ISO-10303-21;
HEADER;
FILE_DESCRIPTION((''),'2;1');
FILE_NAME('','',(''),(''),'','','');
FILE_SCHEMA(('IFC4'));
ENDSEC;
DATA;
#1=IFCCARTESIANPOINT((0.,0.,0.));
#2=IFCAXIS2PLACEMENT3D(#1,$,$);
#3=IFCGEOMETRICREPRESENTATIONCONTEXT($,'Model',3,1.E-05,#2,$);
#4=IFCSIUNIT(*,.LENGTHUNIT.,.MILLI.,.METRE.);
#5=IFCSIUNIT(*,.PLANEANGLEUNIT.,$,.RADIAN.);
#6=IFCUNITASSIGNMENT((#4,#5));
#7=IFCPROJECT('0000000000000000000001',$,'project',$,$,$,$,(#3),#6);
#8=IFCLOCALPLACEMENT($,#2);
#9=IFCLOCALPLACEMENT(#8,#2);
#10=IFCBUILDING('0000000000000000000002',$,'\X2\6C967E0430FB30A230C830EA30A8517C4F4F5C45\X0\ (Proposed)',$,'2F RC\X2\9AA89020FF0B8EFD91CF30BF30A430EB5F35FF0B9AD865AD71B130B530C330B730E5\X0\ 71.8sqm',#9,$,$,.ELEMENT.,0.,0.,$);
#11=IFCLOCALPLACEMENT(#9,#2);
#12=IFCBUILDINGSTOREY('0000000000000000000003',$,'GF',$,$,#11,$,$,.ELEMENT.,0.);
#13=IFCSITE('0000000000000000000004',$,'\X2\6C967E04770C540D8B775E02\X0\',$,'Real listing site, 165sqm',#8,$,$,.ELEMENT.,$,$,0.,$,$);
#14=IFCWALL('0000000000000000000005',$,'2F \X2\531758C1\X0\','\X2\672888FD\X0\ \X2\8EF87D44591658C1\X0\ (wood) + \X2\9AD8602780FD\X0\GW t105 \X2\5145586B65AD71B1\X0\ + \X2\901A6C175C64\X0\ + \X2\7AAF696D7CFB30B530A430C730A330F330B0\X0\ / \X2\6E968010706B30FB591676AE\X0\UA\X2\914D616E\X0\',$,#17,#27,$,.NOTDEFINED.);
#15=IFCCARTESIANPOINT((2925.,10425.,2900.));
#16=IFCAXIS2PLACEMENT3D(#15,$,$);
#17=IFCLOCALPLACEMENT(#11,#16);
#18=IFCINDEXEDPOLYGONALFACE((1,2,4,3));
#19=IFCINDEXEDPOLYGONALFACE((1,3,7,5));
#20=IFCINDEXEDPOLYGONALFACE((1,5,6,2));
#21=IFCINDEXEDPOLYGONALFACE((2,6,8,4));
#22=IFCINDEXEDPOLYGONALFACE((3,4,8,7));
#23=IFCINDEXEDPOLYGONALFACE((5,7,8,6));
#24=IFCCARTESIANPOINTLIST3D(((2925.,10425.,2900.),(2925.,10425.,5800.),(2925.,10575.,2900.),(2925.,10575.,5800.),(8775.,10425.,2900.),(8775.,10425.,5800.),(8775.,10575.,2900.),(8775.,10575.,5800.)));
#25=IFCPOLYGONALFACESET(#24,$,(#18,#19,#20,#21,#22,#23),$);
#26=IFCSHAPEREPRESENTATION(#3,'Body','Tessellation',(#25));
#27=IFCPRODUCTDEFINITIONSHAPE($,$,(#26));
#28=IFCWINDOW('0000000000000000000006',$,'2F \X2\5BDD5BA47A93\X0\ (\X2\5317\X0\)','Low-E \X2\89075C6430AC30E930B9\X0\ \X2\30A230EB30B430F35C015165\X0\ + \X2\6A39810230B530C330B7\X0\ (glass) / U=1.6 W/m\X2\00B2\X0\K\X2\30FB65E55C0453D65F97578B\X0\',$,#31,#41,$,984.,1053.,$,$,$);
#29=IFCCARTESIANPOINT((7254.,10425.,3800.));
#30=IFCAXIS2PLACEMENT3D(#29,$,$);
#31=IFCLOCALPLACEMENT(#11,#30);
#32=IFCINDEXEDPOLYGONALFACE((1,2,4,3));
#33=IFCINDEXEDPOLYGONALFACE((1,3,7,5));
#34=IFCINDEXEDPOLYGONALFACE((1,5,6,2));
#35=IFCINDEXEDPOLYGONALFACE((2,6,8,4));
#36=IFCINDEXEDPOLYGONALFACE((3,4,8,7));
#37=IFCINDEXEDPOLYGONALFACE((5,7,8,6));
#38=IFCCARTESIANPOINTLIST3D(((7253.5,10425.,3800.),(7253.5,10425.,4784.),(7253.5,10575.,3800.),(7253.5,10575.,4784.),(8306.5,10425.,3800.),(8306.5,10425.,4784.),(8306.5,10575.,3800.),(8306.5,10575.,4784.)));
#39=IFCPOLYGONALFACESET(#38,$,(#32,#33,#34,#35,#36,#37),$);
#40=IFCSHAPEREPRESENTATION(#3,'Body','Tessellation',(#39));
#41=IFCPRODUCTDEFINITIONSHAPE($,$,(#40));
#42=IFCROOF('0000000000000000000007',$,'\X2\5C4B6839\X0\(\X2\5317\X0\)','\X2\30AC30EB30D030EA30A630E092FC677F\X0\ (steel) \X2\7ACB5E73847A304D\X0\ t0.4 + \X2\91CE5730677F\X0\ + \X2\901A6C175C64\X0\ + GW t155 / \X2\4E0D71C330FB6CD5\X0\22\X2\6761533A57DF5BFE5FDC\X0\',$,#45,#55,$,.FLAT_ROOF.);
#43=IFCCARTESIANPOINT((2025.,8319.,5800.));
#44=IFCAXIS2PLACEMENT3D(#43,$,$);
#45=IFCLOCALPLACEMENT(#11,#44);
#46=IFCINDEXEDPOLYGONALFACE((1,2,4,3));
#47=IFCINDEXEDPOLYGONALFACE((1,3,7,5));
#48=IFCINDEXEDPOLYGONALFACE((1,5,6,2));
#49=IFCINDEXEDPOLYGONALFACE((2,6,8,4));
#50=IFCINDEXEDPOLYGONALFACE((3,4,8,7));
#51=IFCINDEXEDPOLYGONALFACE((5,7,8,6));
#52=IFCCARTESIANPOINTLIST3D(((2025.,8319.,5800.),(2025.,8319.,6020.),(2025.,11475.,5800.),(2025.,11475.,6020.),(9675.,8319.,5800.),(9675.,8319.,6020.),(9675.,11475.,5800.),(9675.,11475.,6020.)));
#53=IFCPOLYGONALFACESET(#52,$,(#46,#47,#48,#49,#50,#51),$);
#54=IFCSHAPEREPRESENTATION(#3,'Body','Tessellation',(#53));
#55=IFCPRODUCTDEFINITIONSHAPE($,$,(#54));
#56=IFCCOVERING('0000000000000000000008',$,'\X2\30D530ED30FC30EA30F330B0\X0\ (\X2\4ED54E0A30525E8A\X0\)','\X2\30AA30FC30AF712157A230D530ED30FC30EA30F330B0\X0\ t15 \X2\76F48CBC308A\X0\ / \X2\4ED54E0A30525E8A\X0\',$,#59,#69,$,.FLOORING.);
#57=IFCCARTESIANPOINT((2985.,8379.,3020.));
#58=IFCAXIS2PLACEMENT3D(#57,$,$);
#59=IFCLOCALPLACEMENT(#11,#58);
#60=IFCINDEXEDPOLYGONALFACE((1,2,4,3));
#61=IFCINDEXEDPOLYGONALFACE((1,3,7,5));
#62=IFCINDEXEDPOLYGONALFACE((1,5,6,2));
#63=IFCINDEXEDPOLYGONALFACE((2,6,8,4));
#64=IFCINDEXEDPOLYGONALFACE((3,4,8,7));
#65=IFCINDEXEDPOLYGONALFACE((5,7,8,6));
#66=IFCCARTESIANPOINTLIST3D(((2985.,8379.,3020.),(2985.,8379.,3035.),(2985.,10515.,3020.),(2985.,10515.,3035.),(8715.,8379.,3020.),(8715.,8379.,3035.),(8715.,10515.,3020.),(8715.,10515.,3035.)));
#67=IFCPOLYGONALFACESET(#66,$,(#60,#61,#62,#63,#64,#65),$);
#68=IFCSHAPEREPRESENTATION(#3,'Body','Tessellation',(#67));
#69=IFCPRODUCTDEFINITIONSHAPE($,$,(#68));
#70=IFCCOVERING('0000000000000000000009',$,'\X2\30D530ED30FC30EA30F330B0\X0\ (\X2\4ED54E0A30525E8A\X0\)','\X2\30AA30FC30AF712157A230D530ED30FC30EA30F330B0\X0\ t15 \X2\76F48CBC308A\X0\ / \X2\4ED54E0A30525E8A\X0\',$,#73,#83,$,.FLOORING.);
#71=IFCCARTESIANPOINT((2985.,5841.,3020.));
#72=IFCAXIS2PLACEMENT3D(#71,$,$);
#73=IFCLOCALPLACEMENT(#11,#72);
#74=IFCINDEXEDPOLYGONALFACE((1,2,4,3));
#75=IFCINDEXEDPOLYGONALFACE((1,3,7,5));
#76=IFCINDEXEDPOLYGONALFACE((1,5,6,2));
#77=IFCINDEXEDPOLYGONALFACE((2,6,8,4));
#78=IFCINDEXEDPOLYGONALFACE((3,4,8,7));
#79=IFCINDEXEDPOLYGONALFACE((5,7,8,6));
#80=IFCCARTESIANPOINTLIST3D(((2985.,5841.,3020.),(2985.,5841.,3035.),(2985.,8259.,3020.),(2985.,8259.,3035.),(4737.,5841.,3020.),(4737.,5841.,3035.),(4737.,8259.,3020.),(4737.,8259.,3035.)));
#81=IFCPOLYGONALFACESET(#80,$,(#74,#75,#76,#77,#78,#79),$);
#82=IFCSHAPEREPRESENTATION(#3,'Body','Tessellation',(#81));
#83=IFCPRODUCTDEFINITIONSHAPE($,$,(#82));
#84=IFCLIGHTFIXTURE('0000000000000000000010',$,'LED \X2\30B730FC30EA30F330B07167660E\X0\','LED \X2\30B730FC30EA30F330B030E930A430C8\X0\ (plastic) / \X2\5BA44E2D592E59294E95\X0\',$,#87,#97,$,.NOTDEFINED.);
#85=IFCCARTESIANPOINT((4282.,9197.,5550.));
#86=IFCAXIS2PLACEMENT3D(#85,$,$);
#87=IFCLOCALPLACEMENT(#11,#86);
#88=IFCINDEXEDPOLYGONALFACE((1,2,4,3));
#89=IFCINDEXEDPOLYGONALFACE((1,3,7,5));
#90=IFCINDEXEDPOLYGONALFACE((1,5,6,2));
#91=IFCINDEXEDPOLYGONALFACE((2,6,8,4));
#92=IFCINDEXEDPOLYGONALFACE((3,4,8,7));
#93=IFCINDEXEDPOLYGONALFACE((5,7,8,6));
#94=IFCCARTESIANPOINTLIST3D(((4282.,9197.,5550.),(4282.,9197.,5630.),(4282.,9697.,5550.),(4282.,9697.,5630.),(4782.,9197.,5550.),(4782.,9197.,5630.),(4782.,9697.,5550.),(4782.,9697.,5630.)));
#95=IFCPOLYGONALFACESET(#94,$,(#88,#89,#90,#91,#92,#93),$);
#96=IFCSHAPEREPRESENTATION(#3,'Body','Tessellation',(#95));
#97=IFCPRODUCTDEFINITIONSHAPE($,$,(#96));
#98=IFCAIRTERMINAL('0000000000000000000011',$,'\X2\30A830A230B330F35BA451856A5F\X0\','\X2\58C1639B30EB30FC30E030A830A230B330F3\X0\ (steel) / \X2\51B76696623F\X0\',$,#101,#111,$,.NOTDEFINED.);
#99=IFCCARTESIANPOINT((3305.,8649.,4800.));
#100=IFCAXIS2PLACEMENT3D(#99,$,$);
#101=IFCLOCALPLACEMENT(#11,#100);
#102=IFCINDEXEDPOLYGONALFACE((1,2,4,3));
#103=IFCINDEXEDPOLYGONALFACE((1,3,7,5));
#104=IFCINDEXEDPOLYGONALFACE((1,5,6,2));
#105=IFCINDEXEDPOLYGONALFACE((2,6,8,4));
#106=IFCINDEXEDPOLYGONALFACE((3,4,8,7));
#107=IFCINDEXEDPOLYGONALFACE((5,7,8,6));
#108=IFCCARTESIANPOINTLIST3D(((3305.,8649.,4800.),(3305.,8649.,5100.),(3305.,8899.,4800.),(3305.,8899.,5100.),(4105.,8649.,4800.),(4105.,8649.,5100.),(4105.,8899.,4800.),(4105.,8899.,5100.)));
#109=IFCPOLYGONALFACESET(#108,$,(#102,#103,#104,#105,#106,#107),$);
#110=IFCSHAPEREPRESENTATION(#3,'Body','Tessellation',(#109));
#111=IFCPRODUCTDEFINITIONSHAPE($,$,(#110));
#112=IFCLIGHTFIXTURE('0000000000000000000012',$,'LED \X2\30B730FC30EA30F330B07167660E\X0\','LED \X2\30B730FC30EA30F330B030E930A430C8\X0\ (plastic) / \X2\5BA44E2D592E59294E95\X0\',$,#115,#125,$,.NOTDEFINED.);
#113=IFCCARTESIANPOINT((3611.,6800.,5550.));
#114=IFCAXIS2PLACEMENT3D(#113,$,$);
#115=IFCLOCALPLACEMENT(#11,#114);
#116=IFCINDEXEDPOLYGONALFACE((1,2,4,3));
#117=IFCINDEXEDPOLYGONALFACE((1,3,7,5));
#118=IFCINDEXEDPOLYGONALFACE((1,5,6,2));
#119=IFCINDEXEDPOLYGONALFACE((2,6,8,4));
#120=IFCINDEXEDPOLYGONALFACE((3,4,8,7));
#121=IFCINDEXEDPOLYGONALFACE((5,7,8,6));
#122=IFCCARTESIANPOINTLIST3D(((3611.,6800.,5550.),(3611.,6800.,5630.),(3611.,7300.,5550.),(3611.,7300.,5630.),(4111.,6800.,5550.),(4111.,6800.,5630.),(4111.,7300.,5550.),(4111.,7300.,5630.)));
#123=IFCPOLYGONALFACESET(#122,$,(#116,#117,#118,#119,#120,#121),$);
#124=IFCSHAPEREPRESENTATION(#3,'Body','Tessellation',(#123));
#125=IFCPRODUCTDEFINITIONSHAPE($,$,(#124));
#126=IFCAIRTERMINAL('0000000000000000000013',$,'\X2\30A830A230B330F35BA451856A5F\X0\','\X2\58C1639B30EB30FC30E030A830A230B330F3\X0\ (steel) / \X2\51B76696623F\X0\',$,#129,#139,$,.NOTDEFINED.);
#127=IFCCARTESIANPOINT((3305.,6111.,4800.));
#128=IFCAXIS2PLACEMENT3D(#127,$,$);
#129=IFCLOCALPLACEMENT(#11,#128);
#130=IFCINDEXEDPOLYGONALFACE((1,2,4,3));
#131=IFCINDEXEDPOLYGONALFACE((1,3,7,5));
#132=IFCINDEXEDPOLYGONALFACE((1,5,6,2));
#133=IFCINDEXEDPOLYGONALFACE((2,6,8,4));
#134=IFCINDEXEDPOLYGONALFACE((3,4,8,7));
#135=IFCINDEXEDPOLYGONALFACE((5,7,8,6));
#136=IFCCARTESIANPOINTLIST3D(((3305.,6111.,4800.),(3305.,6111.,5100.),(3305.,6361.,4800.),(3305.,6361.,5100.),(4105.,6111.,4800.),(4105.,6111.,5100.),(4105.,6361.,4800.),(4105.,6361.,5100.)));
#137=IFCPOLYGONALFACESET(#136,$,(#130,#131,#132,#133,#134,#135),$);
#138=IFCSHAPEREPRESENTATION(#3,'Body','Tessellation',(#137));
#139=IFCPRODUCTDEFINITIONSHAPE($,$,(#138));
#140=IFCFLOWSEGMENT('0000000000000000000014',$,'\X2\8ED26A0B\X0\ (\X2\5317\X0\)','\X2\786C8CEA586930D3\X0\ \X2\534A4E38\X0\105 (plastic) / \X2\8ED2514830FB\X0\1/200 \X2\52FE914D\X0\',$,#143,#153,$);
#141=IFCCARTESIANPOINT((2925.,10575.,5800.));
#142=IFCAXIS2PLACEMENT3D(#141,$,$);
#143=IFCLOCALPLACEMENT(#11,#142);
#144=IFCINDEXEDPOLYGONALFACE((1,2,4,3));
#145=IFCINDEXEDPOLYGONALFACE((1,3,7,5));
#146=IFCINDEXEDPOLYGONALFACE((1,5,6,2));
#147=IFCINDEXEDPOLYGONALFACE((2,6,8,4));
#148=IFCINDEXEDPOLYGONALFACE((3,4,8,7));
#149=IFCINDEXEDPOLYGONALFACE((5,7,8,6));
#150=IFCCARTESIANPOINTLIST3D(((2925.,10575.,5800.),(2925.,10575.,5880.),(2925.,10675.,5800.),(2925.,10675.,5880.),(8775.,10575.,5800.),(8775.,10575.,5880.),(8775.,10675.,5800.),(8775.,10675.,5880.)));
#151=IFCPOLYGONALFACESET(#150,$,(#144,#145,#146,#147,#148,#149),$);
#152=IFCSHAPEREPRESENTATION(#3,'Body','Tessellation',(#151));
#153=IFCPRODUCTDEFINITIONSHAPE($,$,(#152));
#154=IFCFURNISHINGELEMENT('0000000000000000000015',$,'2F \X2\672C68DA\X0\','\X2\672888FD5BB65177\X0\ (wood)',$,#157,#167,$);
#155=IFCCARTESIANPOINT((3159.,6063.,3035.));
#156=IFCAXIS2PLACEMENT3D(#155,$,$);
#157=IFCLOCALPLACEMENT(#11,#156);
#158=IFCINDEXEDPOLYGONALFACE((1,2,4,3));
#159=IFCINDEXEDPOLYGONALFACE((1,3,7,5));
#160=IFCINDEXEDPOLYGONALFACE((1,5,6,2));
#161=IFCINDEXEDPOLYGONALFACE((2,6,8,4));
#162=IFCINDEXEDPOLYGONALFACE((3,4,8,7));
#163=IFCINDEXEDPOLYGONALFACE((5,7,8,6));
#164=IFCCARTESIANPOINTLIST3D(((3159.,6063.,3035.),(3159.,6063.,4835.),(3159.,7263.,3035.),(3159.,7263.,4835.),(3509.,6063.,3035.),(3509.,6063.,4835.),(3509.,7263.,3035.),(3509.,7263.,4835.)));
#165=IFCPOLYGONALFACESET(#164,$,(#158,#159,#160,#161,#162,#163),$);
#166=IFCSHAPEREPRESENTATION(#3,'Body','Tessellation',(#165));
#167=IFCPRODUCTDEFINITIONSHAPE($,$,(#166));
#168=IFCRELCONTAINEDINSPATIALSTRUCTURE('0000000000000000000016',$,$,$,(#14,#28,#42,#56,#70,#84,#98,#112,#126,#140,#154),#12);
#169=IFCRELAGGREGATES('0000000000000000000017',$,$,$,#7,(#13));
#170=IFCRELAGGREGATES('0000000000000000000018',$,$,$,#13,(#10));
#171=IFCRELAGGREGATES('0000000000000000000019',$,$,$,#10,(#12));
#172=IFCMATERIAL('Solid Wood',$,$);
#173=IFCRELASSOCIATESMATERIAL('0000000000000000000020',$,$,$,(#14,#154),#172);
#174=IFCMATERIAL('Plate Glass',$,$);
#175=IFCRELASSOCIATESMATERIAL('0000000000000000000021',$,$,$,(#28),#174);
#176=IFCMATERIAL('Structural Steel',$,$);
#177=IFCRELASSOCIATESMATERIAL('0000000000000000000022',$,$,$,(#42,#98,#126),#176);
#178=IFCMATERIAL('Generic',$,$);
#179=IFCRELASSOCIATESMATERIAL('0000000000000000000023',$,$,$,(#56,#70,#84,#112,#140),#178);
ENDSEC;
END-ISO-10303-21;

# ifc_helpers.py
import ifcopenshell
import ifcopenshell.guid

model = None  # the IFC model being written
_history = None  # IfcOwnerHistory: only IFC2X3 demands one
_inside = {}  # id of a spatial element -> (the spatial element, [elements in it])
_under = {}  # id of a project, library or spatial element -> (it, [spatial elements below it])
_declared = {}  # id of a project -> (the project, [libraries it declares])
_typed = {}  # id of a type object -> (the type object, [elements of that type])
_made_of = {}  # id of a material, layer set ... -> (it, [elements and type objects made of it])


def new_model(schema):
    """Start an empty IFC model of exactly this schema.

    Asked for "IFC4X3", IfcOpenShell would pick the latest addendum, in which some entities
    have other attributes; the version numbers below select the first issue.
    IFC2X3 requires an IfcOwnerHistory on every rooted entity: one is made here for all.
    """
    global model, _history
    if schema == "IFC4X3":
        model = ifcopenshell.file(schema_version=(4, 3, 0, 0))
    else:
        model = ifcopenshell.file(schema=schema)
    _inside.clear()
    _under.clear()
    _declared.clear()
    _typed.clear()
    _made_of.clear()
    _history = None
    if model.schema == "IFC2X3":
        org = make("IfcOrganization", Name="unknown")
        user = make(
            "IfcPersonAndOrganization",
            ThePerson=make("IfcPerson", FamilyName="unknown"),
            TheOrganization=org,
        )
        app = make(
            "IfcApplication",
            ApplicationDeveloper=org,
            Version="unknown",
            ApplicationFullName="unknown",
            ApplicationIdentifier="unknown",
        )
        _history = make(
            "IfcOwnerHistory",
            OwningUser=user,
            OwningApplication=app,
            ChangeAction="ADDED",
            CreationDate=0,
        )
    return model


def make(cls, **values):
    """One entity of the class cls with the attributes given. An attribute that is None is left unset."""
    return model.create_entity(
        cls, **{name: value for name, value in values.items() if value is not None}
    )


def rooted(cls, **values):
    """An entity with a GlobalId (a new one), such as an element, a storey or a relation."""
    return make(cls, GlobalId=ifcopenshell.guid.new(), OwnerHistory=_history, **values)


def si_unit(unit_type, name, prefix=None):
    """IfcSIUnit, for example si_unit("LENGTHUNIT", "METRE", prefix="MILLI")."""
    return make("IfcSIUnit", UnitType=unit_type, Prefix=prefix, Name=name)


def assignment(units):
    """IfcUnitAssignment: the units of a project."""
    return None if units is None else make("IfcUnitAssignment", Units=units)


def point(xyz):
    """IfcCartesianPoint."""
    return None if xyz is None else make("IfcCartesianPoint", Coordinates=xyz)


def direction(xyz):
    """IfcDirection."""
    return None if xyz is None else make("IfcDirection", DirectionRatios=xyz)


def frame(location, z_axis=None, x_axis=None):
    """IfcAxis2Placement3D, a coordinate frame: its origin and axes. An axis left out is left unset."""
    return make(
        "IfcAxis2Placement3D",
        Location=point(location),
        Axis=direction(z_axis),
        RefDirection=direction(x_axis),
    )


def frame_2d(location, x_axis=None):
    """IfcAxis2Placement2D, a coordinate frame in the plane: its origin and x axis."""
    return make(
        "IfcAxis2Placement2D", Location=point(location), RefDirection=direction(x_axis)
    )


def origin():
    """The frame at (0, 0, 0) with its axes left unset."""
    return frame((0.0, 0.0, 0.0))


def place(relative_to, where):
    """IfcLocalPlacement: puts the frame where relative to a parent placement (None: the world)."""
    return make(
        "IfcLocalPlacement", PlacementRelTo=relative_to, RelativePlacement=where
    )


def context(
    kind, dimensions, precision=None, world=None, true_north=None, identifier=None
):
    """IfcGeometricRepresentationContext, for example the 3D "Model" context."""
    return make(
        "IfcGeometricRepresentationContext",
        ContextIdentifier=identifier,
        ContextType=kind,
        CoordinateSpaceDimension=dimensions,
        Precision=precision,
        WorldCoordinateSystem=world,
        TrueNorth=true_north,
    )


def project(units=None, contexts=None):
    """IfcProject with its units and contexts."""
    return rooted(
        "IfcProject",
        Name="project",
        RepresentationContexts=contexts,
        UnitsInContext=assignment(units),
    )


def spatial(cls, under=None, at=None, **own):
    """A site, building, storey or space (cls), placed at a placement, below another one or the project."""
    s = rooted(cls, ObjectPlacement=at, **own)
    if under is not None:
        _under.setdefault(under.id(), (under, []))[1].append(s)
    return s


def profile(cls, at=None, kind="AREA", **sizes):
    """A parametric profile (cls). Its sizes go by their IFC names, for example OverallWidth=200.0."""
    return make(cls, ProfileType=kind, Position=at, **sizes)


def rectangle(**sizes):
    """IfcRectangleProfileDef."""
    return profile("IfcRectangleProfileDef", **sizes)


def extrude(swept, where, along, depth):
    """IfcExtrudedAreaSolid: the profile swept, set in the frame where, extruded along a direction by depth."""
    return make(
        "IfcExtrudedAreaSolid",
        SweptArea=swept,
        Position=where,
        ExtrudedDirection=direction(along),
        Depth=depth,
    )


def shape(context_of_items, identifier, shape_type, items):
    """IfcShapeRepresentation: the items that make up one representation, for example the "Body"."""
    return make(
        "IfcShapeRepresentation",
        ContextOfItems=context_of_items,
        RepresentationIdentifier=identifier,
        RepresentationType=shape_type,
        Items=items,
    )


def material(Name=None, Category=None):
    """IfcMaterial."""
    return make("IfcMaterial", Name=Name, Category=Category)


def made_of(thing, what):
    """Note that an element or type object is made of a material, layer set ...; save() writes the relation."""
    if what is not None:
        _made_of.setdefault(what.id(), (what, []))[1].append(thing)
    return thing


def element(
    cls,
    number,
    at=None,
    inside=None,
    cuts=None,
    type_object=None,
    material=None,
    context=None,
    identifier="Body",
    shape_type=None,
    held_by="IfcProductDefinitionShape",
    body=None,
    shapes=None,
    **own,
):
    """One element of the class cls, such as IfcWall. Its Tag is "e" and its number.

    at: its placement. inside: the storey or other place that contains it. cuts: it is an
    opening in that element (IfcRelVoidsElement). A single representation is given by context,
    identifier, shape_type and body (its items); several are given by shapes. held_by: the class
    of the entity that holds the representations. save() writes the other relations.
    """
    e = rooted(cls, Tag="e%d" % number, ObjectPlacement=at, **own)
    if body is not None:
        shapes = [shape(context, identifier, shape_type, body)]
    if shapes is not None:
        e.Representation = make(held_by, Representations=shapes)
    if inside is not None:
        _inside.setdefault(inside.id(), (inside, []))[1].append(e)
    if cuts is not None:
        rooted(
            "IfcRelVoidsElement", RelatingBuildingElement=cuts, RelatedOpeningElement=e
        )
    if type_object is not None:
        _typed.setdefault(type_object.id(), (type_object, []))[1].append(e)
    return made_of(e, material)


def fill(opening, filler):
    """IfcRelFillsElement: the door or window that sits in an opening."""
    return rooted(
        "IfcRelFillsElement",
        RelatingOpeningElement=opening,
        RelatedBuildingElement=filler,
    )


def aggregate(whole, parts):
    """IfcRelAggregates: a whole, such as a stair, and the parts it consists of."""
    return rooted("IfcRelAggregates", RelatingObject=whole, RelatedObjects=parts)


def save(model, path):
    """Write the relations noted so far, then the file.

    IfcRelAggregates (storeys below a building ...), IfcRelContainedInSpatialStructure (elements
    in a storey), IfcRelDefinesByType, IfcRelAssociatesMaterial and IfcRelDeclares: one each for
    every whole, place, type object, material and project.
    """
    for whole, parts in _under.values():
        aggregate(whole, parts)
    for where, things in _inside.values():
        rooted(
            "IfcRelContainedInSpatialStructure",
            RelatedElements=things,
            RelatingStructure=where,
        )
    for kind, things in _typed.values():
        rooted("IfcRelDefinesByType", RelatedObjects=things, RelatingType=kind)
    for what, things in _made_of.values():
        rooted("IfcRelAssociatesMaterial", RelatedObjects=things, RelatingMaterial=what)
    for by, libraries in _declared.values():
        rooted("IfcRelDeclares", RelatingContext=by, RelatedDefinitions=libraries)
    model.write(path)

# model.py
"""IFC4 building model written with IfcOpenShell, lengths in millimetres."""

from ifc_helpers import new_model, si_unit, frame, frame_2d, origin, place, context, project, spatial, rectangle, extrude, material, element, fill, save


model = new_model("IFC4")

# Units and contexts
model_context = context("Model", 3, precision=1e-05, world=origin())
ifc_project = project(units=[si_unit("LENGTHUNIT", "METRE", prefix="MILLI"), si_unit("PLANEANGLEUNIT", "RADIAN")], contexts=[model_context])

# Site, building, storey
site_placement = place(None, origin())
site = spatial("IfcSite", under=ifc_project, at=site_placement, Name="沖縄県名護市", ObjectType="Real listing site, 165sqm", CompositionType="ELEMENT", RefElevation=0.0)
building_placement = place(site_placement, origin())
building = spatial("IfcBuilding", under=site, at=building_placement, Name="沖縄・アトリエ兼住居 (Proposed)", ObjectType="2F RC骨造＋軽量タイル張＋高断熱サッシュ 71.8sqm", CompositionType="ELEMENT", ElevationOfRefHeight=0.0, ElevationOfTerrain=0.0)
storey_placement = place(building_placement, origin())
storey = spatial("IfcBuildingStorey", under=building, at=storey_placement, Name="GF", CompositionType="ELEMENT", Elevation=0.0)

# Shared definitions
ifc_material_1 = material(Name="Solid Wood")

# Wall, opening, window
wall_placement = place(storey_placement, frame((2925.0, 10425.0, 2900.0)))
wall = element("IfcWall", 1, at=wall_placement, inside=storey, material=ifc_material_1, Name="2F 北壁", Description="木製 軸組外壁 (wood) + 高性能GW t105 充填断熱 + 通気層 + 窯業系サイディング / 準耐火・外皮UA配慮", PredefinedType="NOTDEFINED", context=model_context, shape_type="SweptSolid", body=[
    extrude(rectangle(XDim=5850.0, YDim=150.0, at=frame_2d((2925.0, 75.0))), frame((2925.0, 10425.0, 2900.0)), (0.0, 0.0, 1.0), 2900.0),
])
opening_placement = place(storey_placement, frame((7254.0, 10425.0, 3800.0)))
opening = element("IfcOpeningElement", 2, at=opening_placement, cuts=wall, PredefinedType="NOTDEFINED", context=model_context, shape_type="SweptSolid", body=[
    extrude(rectangle(XDim=1053.0, YDim=150.0, at=frame_2d((526.0, 75.0))), frame((7254.0, 10425.0, 3800.0)), (0.0, 0.0, 1.0), 984.0),
])
ifc_material_2 = material(Name="Plate Glass")
window_placement = place(storey_placement, frame((7254.0, 10425.0, 3800.0)))
window = element("IfcWindow", 3, at=window_placement, inside=storey, material=ifc_material_2, Name="2F 寝室窓 (北)", Description="Low-E 複層ガラス アルゴン封入 + 樹脂サッシ (glass) / U=1.6 W/m²K・日射取得型", OverallHeight=984.0, OverallWidth=1053.0, context=model_context, shape_type="SweptSolid", body=[
    extrude(rectangle(XDim=1053.0, YDim=150.0, at=frame_2d((526.0, 75.0))), frame((7254.0, 10425.0, 3800.0)), (0.0, 0.0, 1.0), 984.0),
])
fill(opening, window)

# Roof
ifc_material_3 = material(Name="Structural Steel")
for number, where, name in (
    (4, (2025.0, 8319.0, 5800.0), "屋根(北)"),
):
    element("IfcRoof", number, at=place(storey_placement, frame(where)), inside=storey, material=ifc_material_3, Name=name, Description="ガルバリウム鋼板 (steel) 立平葺き t0.4 + 野地板 + 通気層 + GW t155 / 不燃・法22条区域対応", PredefinedType="FLAT_ROOF", context=model_context, shape_type="SweptSolid", body=[
        extrude(rectangle(XDim=7650.0, YDim=3156.0, at=frame_2d((3825.0, 1578.0))), frame((2025.0, 8319.0, 5800.0)), (0.0, 0.0, 1.0), 220.0),
    ])

# Coverings
ifc_material_4 = material(Name="Generic")
covering_1_placement = place(storey_placement, frame((2985.0, 8379.0, 3020.0)))
element("IfcCovering", 5, at=covering_1_placement, inside=storey, material=ifc_material_4, Name="フローリング (仕上げ床)", Description="オーク無垢フローリング t15 直貼り / 仕上げ床", PredefinedType="FLOORING", context=model_context, shape_type="SweptSolid", body=[
    extrude(rectangle(XDim=5730.0, YDim=2136.0, at=frame_2d((2865.0, 1068.0))), frame((2985.0, 8379.0, 3020.0)), (0.0, 0.0, 1.0), 15.0),
])
covering_2_placement = place(storey_placement, frame((2985.0, 5841.0, 3020.0)))
element("IfcCovering", 6, at=covering_2_placement, inside=storey, material=ifc_material_4, Name="フローリング (仕上げ床)", Description="オーク無垢フローリング t15 直貼り / 仕上げ床", PredefinedType="FLOORING", context=model_context, shape_type="SweptSolid", body=[
    extrude(rectangle(XDim=1752.0, YDim=2418.0, at=frame_2d((876.0, 1209.0))), frame((2985.0, 5841.0, 3020.0)), (0.0, 0.0, 1.0), 15.0),
])

# Light fixture
light_fixture_1_placement = place(storey_placement, frame((4282.0, 9197.0, 5550.0)))
element("IfcLightFixture", 7, at=light_fixture_1_placement, inside=storey, material=ifc_material_4, Name="LED シーリング照明", Description="LED シーリングライト (plastic) / 室中央天井", PredefinedType="NOTDEFINED", context=model_context, shape_type="SweptSolid", body=[
    extrude(rectangle(XDim=500.0, YDim=500.0, at=frame_2d((250.0, 250.0))), frame((4282.0, 9197.0, 5550.0)), (0.0, 0.0, 1.0), 80.0),
])

# Air terminal
air_terminal_1_placement = place(storey_placement, frame((3305.0, 8649.0, 4800.0)))
element("IfcAirTerminal", 8, at=air_terminal_1_placement, inside=storey, material=ifc_material_3, Name="エアコン室内機", Description="壁掛ルームエアコン (steel) / 冷暖房", PredefinedType="NOTDEFINED", context=model_context, shape_type="SweptSolid", body=[
    extrude(rectangle(XDim=800.0, YDim=250.0, at=frame_2d((400.0, 125.0))), frame((3305.0, 8649.0, 4800.0)), (0.0, 0.0, 1.0), 300.0),
])

# Light fixture
light_fixture_2_placement = place(storey_placement, frame((3611.0, 6800.0, 5550.0)))
element("IfcLightFixture", 9, at=light_fixture_2_placement, inside=storey, material=ifc_material_4, Name="LED シーリング照明", Description="LED シーリングライト (plastic) / 室中央天井", PredefinedType="NOTDEFINED", context=model_context, shape_type="SweptSolid", body=[
    extrude(rectangle(XDim=500.0, YDim=500.0, at=frame_2d((250.0, 250.0))), frame((3611.0, 6800.0, 5550.0)), (0.0, 0.0, 1.0), 80.0),
])

# Air terminal
air_terminal_2_placement = place(storey_placement, frame((3305.0, 6111.0, 4800.0)))
element("IfcAirTerminal", 10, at=air_terminal_2_placement, inside=storey, material=ifc_material_3, Name="エアコン室内機", Description="壁掛ルームエアコン (steel) / 冷暖房", PredefinedType="NOTDEFINED", context=model_context, shape_type="SweptSolid", body=[
    extrude(rectangle(XDim=800.0, YDim=250.0, at=frame_2d((400.0, 125.0))), frame((3305.0, 6111.0, 4800.0)), (0.0, 0.0, 1.0), 300.0),
])

# Flow segment
flow_segment_placement = place(storey_placement, frame((2925.0, 10575.0, 5800.0)))
element("IfcFlowSegment", 11, at=flow_segment_placement, inside=storey, material=ifc_material_4, Name="軒樋 (北)", Description="硬質塩ビ 半丸105 (plastic) / 軒先・1/200 勾配", context=model_context, shape_type="SweptSolid", body=[
    extrude(rectangle(XDim=5850.0, YDim=100.0, at=frame_2d((2925.0, 50.0))), frame((2925.0, 10575.0, 5800.0)), (0.0, 0.0, 1.0), 80.0),
])

# Furnishing element
furnishing_placement = place(storey_placement, frame((3159.0, 6063.0, 3035.0)))
element("IfcFurnishingElement", 12, at=furnishing_placement, inside=storey, material=ifc_material_1, Name="2F 本棚", Description="木製家具 (wood)", context=model_context, shape_type="SweptSolid", body=[
    extrude(rectangle(XDim=350.0, YDim=1200.0, at=frame_2d((175.0, 600.0))), frame((3159.0, 6063.0, 3035.0)), (0.0, 0.0, 1.0), 1800.0),
])

save(model, "model.ifc")
